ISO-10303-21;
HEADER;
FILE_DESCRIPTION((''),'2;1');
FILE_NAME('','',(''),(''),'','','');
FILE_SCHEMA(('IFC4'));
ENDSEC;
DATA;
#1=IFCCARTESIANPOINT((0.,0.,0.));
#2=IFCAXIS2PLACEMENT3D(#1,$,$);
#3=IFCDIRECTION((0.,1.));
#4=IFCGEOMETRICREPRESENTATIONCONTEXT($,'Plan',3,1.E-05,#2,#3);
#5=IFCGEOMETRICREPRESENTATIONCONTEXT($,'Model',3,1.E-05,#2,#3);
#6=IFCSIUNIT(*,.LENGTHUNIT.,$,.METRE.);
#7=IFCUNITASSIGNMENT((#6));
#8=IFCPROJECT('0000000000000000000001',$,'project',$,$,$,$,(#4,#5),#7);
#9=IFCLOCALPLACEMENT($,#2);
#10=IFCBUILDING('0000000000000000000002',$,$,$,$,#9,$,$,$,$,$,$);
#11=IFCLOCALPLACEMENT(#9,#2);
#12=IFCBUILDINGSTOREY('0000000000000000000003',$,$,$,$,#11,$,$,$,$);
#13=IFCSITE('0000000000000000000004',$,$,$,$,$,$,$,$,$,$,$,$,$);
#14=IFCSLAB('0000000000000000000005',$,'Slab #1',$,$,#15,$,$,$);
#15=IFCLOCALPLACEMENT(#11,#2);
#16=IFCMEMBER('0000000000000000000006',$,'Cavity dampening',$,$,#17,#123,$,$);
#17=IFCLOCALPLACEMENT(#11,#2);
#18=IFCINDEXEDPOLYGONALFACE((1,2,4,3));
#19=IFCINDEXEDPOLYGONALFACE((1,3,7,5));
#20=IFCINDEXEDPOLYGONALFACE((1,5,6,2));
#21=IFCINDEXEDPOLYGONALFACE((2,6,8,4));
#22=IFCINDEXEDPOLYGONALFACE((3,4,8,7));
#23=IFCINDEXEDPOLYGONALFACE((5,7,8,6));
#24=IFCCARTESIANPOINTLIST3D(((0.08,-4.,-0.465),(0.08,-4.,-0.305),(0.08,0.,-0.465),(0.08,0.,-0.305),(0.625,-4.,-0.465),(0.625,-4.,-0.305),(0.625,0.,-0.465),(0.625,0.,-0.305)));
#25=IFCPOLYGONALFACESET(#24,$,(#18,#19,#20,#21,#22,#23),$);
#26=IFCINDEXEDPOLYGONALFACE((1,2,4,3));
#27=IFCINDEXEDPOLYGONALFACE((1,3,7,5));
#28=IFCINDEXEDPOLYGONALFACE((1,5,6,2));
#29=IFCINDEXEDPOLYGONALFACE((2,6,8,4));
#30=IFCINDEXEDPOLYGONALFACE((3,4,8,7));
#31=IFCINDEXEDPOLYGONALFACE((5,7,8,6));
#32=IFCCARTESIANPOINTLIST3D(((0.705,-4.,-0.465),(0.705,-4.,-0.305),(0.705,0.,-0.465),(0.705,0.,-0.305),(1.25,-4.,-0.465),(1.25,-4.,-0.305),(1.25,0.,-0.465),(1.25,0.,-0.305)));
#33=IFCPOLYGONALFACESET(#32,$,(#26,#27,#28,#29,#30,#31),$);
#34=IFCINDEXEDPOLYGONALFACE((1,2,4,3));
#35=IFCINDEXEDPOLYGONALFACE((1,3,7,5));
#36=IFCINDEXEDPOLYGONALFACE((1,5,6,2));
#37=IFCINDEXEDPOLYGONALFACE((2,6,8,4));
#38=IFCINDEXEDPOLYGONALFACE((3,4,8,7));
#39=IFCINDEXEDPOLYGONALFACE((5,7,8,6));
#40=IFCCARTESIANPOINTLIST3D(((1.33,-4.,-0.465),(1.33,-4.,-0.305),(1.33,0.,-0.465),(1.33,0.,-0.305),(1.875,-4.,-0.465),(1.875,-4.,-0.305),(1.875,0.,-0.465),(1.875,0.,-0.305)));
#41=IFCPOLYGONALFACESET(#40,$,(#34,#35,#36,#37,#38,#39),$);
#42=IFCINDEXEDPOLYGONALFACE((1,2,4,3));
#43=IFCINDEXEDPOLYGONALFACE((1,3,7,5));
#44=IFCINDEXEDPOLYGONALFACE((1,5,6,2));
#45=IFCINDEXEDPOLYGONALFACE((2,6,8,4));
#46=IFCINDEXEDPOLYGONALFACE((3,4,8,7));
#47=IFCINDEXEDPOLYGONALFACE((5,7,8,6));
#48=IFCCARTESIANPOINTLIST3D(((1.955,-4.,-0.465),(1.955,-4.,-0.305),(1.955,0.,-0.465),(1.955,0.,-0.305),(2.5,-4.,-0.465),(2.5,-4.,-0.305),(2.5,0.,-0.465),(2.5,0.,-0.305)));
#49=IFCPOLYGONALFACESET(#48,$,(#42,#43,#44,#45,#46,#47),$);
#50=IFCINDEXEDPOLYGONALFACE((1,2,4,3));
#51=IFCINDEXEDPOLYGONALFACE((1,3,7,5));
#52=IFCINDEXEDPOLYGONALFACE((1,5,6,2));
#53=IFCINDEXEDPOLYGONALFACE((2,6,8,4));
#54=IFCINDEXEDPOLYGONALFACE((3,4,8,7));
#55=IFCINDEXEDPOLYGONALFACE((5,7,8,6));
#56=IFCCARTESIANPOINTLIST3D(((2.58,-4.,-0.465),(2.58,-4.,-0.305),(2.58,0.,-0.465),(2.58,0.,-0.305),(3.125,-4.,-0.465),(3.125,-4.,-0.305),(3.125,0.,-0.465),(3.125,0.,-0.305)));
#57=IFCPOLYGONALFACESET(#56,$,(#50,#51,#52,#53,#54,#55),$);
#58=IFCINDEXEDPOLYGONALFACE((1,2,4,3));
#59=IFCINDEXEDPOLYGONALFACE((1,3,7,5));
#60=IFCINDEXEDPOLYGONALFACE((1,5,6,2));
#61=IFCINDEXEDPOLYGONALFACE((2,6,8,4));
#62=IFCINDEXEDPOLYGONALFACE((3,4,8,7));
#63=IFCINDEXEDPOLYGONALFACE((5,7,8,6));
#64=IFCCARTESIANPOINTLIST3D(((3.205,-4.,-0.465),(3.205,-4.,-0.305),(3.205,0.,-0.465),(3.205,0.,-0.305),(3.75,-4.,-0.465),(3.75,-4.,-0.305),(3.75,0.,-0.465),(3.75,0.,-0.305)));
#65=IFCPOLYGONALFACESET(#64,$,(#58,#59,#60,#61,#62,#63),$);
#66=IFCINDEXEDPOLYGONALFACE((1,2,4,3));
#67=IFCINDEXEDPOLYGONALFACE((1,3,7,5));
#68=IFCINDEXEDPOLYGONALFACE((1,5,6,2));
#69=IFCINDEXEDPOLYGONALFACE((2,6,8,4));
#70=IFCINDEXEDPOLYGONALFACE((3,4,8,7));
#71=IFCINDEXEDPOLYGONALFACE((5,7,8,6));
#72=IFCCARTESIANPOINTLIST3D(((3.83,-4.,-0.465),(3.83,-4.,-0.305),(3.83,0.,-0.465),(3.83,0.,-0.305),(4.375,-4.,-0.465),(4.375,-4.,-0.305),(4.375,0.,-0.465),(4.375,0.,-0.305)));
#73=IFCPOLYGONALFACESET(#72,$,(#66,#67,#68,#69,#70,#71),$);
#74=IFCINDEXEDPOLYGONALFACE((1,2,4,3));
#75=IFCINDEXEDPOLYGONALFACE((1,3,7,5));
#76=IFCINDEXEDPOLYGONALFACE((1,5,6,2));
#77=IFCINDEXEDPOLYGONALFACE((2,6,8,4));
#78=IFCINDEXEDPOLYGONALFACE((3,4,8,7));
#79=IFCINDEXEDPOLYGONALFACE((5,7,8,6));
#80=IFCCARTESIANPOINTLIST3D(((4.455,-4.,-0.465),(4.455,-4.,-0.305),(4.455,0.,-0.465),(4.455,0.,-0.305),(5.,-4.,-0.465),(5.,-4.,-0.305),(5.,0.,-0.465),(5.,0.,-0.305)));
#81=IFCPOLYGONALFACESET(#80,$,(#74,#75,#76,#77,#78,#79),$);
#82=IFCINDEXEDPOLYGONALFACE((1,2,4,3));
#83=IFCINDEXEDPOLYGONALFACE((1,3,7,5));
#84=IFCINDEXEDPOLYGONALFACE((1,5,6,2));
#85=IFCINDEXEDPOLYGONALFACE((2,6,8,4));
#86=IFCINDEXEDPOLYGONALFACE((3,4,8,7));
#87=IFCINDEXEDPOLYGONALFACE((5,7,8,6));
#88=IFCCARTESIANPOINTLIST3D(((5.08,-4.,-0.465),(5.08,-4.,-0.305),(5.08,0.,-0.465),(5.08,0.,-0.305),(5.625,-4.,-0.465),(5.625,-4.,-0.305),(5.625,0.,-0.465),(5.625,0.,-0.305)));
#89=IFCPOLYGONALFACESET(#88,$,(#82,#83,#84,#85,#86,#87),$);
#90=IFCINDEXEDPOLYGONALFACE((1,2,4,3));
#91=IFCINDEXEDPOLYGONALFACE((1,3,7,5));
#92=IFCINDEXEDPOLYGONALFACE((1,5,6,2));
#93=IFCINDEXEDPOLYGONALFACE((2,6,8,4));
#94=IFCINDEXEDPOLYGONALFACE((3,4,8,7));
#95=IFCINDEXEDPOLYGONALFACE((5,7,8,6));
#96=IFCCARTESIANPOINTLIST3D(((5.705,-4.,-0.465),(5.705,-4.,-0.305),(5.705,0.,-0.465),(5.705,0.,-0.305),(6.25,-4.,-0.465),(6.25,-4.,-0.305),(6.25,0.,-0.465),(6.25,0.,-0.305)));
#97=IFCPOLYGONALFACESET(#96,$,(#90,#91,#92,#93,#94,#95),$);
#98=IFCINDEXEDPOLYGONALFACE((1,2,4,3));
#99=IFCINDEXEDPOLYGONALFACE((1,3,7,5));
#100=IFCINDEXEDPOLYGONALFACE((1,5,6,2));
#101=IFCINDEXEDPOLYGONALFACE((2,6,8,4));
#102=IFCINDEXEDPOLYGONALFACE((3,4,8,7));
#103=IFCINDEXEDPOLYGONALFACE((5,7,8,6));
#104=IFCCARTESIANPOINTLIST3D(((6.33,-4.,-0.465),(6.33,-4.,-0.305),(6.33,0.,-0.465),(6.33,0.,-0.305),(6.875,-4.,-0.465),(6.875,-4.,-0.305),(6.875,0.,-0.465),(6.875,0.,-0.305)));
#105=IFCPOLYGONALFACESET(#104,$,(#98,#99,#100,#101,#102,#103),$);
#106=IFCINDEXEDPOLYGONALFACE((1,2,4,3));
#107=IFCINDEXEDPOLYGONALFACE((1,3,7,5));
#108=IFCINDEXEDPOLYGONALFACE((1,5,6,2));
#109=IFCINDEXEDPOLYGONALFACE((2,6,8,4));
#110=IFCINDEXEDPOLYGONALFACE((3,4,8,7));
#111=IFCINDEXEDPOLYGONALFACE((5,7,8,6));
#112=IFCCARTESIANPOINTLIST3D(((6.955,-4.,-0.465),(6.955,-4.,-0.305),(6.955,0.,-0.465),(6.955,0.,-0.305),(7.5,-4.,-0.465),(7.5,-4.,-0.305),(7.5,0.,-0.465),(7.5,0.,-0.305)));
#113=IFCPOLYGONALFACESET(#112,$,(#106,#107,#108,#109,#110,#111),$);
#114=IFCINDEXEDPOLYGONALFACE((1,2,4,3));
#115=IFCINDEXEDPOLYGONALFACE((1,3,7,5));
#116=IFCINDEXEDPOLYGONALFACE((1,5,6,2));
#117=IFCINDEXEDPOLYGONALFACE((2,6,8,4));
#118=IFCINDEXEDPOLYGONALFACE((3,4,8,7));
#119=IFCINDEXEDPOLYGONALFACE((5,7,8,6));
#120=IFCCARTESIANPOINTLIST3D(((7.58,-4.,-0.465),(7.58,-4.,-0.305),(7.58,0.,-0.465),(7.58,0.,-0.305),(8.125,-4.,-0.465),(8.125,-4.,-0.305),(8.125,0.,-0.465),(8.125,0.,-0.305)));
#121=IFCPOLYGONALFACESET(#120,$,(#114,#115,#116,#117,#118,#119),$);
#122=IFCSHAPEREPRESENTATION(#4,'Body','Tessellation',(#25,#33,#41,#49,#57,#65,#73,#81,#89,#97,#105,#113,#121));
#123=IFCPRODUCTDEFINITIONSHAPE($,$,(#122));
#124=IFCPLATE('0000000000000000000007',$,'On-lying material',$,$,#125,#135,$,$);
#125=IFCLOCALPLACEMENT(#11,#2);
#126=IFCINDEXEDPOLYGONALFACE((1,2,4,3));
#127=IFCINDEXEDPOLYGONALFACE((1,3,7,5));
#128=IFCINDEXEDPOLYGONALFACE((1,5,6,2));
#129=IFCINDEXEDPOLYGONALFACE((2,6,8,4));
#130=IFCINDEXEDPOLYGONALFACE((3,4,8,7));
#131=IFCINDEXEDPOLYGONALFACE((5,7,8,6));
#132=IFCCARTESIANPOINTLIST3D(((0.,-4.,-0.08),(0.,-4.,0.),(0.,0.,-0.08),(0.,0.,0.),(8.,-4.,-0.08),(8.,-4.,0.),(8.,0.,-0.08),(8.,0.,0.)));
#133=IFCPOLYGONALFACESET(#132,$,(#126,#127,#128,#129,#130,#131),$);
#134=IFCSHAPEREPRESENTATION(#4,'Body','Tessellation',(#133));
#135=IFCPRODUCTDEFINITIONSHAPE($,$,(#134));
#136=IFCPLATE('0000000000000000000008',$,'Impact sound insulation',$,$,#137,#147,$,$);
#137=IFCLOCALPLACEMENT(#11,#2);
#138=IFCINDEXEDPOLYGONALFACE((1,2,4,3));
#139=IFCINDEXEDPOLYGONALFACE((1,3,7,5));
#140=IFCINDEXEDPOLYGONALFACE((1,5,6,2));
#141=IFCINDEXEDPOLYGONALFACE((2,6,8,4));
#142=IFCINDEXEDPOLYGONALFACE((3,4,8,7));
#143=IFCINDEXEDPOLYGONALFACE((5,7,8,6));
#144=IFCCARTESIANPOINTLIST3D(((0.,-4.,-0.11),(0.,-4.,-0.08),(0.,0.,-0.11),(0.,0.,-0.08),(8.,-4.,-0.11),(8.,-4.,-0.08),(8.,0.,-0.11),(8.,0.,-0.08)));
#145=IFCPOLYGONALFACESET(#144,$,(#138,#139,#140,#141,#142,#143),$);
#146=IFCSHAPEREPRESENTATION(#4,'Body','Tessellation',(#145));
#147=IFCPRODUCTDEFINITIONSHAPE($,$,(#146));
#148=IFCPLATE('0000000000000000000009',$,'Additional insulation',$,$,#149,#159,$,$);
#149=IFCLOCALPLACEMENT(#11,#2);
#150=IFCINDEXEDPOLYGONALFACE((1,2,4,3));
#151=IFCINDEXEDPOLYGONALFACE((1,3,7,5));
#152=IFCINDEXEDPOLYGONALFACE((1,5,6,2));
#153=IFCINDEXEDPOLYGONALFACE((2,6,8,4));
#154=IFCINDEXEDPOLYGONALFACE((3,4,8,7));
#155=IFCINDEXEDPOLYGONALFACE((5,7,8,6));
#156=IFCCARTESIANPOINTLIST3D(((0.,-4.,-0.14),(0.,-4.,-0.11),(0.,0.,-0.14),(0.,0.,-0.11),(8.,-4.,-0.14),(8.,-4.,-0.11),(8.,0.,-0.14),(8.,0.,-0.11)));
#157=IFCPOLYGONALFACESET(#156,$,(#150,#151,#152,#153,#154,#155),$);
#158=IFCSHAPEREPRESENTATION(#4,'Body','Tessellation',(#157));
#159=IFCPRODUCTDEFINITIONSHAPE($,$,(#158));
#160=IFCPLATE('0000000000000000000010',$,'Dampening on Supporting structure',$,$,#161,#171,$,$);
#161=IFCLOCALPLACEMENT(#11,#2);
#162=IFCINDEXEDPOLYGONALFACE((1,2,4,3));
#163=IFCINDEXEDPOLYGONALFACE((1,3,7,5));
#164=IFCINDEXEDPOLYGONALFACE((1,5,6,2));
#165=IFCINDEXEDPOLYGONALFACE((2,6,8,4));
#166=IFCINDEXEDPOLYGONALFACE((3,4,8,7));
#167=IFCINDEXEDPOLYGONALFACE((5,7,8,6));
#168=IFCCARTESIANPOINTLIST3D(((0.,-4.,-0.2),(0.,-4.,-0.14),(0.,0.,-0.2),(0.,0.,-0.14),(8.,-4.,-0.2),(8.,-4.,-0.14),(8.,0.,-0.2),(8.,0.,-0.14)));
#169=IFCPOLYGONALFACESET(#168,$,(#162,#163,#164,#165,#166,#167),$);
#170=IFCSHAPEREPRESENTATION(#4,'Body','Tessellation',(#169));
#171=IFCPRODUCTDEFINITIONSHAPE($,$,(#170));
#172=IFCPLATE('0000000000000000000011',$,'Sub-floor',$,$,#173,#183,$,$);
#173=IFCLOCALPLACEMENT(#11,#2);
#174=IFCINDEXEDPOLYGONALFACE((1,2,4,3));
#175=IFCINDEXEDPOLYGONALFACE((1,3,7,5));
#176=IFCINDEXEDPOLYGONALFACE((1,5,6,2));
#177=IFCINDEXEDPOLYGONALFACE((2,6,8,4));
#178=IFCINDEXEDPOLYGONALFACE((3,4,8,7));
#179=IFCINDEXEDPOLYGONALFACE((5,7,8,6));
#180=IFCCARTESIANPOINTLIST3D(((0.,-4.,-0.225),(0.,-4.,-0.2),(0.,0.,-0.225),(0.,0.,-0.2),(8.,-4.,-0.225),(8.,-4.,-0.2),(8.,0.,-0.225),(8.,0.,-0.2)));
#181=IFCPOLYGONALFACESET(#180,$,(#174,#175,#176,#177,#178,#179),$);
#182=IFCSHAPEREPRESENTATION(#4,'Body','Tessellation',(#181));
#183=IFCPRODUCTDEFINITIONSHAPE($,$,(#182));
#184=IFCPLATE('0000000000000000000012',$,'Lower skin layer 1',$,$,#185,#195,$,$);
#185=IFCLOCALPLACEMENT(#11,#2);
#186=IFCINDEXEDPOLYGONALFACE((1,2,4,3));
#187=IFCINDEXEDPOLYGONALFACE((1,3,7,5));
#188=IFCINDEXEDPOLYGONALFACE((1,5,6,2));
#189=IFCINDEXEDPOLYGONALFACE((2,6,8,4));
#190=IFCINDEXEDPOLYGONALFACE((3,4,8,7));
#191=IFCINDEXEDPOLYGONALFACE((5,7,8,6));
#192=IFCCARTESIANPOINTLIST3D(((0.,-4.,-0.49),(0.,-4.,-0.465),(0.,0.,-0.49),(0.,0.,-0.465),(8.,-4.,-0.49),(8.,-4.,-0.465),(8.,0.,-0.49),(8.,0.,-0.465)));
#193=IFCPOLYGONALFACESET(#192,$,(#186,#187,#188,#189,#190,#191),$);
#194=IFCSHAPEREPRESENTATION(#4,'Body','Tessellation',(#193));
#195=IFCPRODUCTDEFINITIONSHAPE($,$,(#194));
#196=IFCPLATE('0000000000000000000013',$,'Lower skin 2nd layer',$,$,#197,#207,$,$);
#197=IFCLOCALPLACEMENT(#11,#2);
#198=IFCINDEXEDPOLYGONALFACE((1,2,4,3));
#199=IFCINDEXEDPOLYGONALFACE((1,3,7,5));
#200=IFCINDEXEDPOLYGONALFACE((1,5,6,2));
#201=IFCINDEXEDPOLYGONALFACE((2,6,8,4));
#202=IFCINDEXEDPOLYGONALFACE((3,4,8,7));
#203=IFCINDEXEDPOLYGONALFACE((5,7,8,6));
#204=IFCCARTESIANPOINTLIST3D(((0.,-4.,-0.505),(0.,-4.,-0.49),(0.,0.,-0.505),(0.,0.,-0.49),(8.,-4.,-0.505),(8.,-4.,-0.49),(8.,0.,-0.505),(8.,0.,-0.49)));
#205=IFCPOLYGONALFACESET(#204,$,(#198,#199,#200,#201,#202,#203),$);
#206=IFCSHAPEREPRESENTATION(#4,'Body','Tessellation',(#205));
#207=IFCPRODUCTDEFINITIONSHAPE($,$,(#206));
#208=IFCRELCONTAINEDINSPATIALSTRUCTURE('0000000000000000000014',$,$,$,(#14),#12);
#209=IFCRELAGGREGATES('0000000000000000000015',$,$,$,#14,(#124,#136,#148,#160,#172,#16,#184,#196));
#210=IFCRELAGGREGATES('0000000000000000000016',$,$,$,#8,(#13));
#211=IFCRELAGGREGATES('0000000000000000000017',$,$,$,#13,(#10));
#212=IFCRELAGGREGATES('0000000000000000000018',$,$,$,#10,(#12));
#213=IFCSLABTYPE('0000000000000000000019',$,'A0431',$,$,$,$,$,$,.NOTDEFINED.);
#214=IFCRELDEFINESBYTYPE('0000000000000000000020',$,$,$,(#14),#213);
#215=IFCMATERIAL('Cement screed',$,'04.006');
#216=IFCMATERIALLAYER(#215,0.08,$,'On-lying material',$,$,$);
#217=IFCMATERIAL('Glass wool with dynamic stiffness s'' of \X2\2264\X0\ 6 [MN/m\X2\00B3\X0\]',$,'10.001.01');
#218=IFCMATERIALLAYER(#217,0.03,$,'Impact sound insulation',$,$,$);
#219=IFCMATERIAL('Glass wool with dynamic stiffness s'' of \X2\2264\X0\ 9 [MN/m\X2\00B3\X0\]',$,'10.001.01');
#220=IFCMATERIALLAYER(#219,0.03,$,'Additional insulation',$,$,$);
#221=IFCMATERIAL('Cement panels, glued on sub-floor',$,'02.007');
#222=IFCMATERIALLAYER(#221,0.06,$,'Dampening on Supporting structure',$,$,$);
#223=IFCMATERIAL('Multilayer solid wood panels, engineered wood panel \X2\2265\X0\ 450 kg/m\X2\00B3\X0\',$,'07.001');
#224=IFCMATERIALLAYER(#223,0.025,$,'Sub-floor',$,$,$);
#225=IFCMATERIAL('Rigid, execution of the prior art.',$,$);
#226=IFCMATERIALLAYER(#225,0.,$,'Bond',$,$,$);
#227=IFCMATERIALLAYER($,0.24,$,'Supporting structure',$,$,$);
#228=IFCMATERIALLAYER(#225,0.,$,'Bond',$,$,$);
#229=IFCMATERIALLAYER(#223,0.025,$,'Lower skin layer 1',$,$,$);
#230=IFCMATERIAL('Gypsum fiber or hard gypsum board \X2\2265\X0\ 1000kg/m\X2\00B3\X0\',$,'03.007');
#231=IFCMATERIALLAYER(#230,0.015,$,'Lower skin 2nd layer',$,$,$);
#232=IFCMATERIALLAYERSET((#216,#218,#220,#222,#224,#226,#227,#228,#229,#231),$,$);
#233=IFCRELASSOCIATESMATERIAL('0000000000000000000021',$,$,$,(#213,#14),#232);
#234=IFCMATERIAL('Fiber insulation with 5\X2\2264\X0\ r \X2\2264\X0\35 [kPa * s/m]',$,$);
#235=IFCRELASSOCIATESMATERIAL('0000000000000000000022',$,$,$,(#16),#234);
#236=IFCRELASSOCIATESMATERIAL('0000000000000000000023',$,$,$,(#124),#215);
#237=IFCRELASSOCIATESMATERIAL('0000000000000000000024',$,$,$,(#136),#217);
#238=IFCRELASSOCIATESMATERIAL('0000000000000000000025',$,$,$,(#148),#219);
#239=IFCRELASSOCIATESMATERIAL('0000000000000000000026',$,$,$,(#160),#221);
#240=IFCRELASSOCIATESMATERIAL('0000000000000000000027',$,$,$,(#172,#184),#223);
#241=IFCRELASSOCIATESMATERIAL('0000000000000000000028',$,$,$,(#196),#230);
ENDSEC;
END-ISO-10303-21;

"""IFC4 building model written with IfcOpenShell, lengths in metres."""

from ifc_helpers import new_model, si_unit, direction, frame, frame_2d, origin, origin_with_axes, place, context, project, spatial, rectangle, extrude, material, layer, layer_set, type_object, element, aggregate, save


model = new_model("IFC4")

# Units and contexts
plan_context = context("Plan", 3, precision=1e-05, world=origin(), true_north=direction((0.0, 1.0)))
model_context = context("Model", 3, precision=1e-05, world=origin(), true_north=direction((0.0, 1.0)))
ifc_project = project(units=[si_unit("LENGTHUNIT", "METRE")], contexts=[plan_context, model_context])

# Site, building, storey
site = spatial("IfcSite", under=ifc_project)
building_placement = place(None, origin())
building = spatial("IfcBuilding", under=site, at=building_placement)
storey_placement = place(building_placement, origin())
storey = spatial("IfcBuildingStorey", under=building, at=storey_placement)

# Slab, member, plates
ifc_material_1 = material(Name="Cement screed", Category="04.006")
ifc_layer_1 = layer(ifc_material_1, 0.08, Name="On-lying material")
ifc_material_2 = material(Name="Glass wool with dynamic stiffness s' of ≤ 6 [MN/m³]", Category="10.001.01")
ifc_layer_2 = layer(ifc_material_2, 0.03, Name="Impact sound insulation")
ifc_material_3 = material(Name="Glass wool with dynamic stiffness s' of ≤ 9 [MN/m³]", Category="10.001.01")
ifc_layer_3 = layer(ifc_material_3, 0.03, Name="Additional insulation")
ifc_material_4 = material(Name="Cement panels, glued on sub-floor", Category="02.007")
ifc_layer_4 = layer(ifc_material_4, 0.06, Name="Dampening on Supporting structure")
ifc_material_5 = material(Name="Multilayer solid wood panels, engineered wood panel ≥ 450 kg/m³", Category="07.001")
ifc_layer_5 = layer(ifc_material_5, 0.025, Name="Sub-floor")
ifc_material_6 = material(Name="Rigid, execution of the prior art.")
ifc_layer_6 = layer(ifc_material_6, 0.0, Name="Bond")
ifc_layer_7 = layer(None, 0.24, Name="Supporting structure")
ifc_layer_8 = layer(ifc_material_6, 0.0, Name="Bond")
ifc_layer_9 = layer(ifc_material_5, 0.025, Name="Lower skin layer 1")
ifc_material_7 = material(Name="Gypsum fiber or hard gypsum board ≥ 1000kg/m³", Category="03.007")
ifc_layer_10 = layer(ifc_material_7, 0.015, Name="Lower skin 2nd layer")
ifc_layer_set = layer_set([ifc_layer_1, ifc_layer_2, ifc_layer_3, ifc_layer_4, ifc_layer_5, ifc_layer_6, ifc_layer_7, ifc_layer_8, ifc_layer_9, ifc_layer_10])
slab_type = type_object("IfcSlabType", Name="A0431", PredefinedType="NOTDEFINED", material=ifc_layer_set)
slab_placement = place(None, frame((0.0, 0.0, 0.0), z_axis=(0.0, 0.0, -1.0), x_axis=(1.0, 0.0, 0.0)))
slab = element("IfcSlab", 1, at=slab_placement, inside=storey, type_object=slab_type, material=ifc_layer_set, Name="Slab #1")
ifc_material_8 = material(Name="Fiber insulation with 5≤ r ≤35 [kPa * s/m]")
member_1_placement = place(slab_placement, origin())
member_1 = element("IfcMember", 2, at=member_1_placement, material=ifc_material_8, Name="Cavity dampening", context=plan_context, shape_type="SweptSolid", body=[
    extrude(rectangle(XDim=0.545, YDim=0.16, at=frame_2d((0.2725, 0.08), x_axis=(1.0, 0.0))), frame((0.08, 4.0, 0.305), z_axis=(0.0, -1.0, 0.0), x_axis=(1.0, 0.0, 0.0)), (0.0, 0.0, 1.0), 4.0),
    extrude(rectangle(XDim=0.545, YDim=0.16, at=frame_2d((0.2725, 0.08), x_axis=(1.0, 0.0))), frame((0.705, 4.0, 0.305), z_axis=(0.0, -1.0, 0.0), x_axis=(1.0, 0.0, 0.0)), (0.0, 0.0, 1.0), 4.0),
    extrude(rectangle(XDim=0.545, YDim=0.16, at=frame_2d((0.2725, 0.08), x_axis=(1.0, 0.0))), frame((1.33, 4.0, 0.305), z_axis=(0.0, -1.0, 0.0), x_axis=(1.0, 0.0, 0.0)), (0.0, 0.0, 1.0), 4.0),
    extrude(rectangle(XDim=0.545, YDim=0.16, at=frame_2d((0.2725, 0.08), x_axis=(1.0, 0.0))), frame((1.955, 4.0, 0.305), z_axis=(0.0, -1.0, 0.0), x_axis=(1.0, 0.0, 0.0)), (0.0, 0.0, 1.0), 4.0),
    extrude(rectangle(XDim=0.545, YDim=0.16, at=frame_2d((0.2725, 0.08), x_axis=(1.0, 0.0))), frame((2.58, 4.0, 0.305), z_axis=(0.0, -1.0, 0.0), x_axis=(1.0, 0.0, 0.0)), (0.0, 0.0, 1.0), 4.0),
    extrude(rectangle(XDim=0.545, YDim=0.16, at=frame_2d((0.2725, 0.08), x_axis=(1.0, 0.0))), frame((3.205, 4.0, 0.305), z_axis=(0.0, -1.0, 0.0), x_axis=(1.0, 0.0, 0.0)), (0.0, 0.0, 1.0), 4.0),
    extrude(rectangle(XDim=0.545, YDim=0.16, at=frame_2d((0.2725, 0.08), x_axis=(1.0, 0.0))), frame((3.83, 4.0, 0.305), z_axis=(0.0, -1.0, 0.0), x_axis=(1.0, 0.0, 0.0)), (0.0, 0.0, 1.0), 4.0),
    extrude(rectangle(XDim=0.545, YDim=0.16, at=frame_2d((0.2725, 0.08), x_axis=(1.0, 0.0))), frame((4.455, 4.0, 0.305), z_axis=(0.0, -1.0, 0.0), x_axis=(1.0, 0.0, 0.0)), (0.0, 0.0, 1.0), 4.0),
    extrude(rectangle(XDim=0.545, YDim=0.16, at=frame_2d((0.2725, 0.08), x_axis=(1.0, 0.0))), frame((5.08, 4.0, 0.305), z_axis=(0.0, -1.0, 0.0), x_axis=(1.0, 0.0, 0.0)), (0.0, 0.0, 1.0), 4.0),
    extrude(rectangle(XDim=0.545, YDim=0.16, at=frame_2d((0.2725, 0.08), x_axis=(1.0, 0.0))), frame((5.705, 4.0, 0.305), z_axis=(0.0, -1.0, 0.0), x_axis=(1.0, 0.0, 0.0)), (0.0, 0.0, 1.0), 4.0),
    extrude(rectangle(XDim=0.545, YDim=0.16, at=frame_2d((0.2725, 0.08), x_axis=(1.0, 0.0))), frame((6.33, 4.0, 0.305), z_axis=(0.0, -1.0, 0.0), x_axis=(1.0, 0.0, 0.0)), (0.0, 0.0, 1.0), 4.0),
    extrude(rectangle(XDim=0.545, YDim=0.16, at=frame_2d((0.2725, 0.08), x_axis=(1.0, 0.0))), frame((6.955, 4.0, 0.305), z_axis=(0.0, -1.0, 0.0), x_axis=(1.0, 0.0, 0.0)), (0.0, 0.0, 1.0), 4.0),
    extrude(rectangle(XDim=0.545, YDim=0.16, at=frame_2d((0.2725, 0.08), x_axis=(1.0, 0.0))), frame((7.58, 4.0, 0.305), z_axis=(0.0, -1.0, 0.0), x_axis=(1.0, 0.0, 0.0)), (0.0, 0.0, 1.0), 4.0),
])
plate_1_placement = place(slab_placement, origin())
plate_1 = element("IfcPlate", 3, at=plate_1_placement, material=ifc_material_1, Name="On-lying material", context=plan_context, shape_type="SweptSolid", body=[
    extrude(rectangle(XDim=8.0, YDim=4.0, at=frame_2d((4.0, 2.0), x_axis=(1.0, 0.0))), origin_with_axes(), (0.0, 0.0, 1.0), 0.08),
])
plate_2_placement = place(slab_placement, origin())
plate_2 = element("IfcPlate", 4, at=plate_2_placement, material=ifc_material_2, Name="Impact sound insulation", context=plan_context, shape_type="SweptSolid", body=[
    extrude(rectangle(XDim=8.0, YDim=4.0, at=frame_2d((4.0, 2.0), x_axis=(1.0, 0.0))), frame((0.0, 0.0, 0.08), z_axis=(0.0, 0.0, 1.0), x_axis=(1.0, 0.0, 0.0)), (0.0, 0.0, 1.0), 0.03),
])
plate_3_placement = place(slab_placement, origin())
plate_3 = element("IfcPlate", 5, at=plate_3_placement, material=ifc_material_3, Name="Additional insulation", context=plan_context, shape_type="SweptSolid", body=[
    extrude(rectangle(XDim=8.0, YDim=4.0, at=frame_2d((4.0, 2.0), x_axis=(1.0, 0.0))), frame((0.0, 0.0, 0.11), z_axis=(0.0, 0.0, 1.0), x_axis=(1.0, 0.0, 0.0)), (0.0, 0.0, 1.0), 0.03),
])
plate_4_placement = place(slab_placement, origin())
plate_4 = element("IfcPlate", 6, at=plate_4_placement, material=ifc_material_4, Name="Dampening on Supporting structure", context=plan_context, shape_type="SweptSolid", body=[
    extrude(rectangle(XDim=8.0, YDim=4.0, at=frame_2d((4.0, 2.0), x_axis=(1.0, 0.0))), frame((0.0, 0.0, 0.14), z_axis=(0.0, 0.0, 1.0), x_axis=(1.0, 0.0, 0.0)), (0.0, 0.0, 1.0), 0.06),
])
plate_5_placement = place(slab_placement, origin())
plate_5 = element("IfcPlate", 7, at=plate_5_placement, material=ifc_material_5, Name="Sub-floor", context=plan_context, shape_type="SweptSolid", body=[
    extrude(rectangle(XDim=8.0, YDim=4.0, at=frame_2d((4.0, 2.0), x_axis=(1.0, 0.0))), frame((0.0, 0.0, 0.2), z_axis=(0.0, 0.0, 1.0), x_axis=(1.0, 0.0, 0.0)), (0.0, 0.0, 1.0), 0.025),
])
plate_6_placement = place(slab_placement, origin())
plate_6 = element("IfcPlate", 8, at=plate_6_placement, material=ifc_material_5, Name="Lower skin layer 1", context=plan_context, shape_type="SweptSolid", body=[
    extrude(rectangle(XDim=8.0, YDim=4.0, at=frame_2d((4.0, 2.0), x_axis=(1.0, 0.0))), frame((0.0, 0.0, 0.465), z_axis=(0.0, 0.0, 1.0), x_axis=(1.0, 0.0, 0.0)), (0.0, 0.0, 1.0), 0.025),
])
plate_7_placement = place(slab_placement, origin())
plate_7 = element("IfcPlate", 9, at=plate_7_placement, material=ifc_material_7, Name="Lower skin 2nd layer", context=plan_context, shape_type="SweptSolid", body=[
    extrude(rectangle(XDim=8.0, YDim=4.0, at=frame_2d((4.0, 2.0), x_axis=(1.0, 0.0))), frame((0.0, 0.0, 0.49), z_axis=(0.0, 0.0, 1.0), x_axis=(1.0, 0.0, 0.0)), (0.0, 0.0, 1.0), 0.015),
])
aggregate(slab, [plate_1, plate_2, plate_3, plate_4, plate_5, member_1, plate_6, plate_7])

save(model, "model.ifc")
